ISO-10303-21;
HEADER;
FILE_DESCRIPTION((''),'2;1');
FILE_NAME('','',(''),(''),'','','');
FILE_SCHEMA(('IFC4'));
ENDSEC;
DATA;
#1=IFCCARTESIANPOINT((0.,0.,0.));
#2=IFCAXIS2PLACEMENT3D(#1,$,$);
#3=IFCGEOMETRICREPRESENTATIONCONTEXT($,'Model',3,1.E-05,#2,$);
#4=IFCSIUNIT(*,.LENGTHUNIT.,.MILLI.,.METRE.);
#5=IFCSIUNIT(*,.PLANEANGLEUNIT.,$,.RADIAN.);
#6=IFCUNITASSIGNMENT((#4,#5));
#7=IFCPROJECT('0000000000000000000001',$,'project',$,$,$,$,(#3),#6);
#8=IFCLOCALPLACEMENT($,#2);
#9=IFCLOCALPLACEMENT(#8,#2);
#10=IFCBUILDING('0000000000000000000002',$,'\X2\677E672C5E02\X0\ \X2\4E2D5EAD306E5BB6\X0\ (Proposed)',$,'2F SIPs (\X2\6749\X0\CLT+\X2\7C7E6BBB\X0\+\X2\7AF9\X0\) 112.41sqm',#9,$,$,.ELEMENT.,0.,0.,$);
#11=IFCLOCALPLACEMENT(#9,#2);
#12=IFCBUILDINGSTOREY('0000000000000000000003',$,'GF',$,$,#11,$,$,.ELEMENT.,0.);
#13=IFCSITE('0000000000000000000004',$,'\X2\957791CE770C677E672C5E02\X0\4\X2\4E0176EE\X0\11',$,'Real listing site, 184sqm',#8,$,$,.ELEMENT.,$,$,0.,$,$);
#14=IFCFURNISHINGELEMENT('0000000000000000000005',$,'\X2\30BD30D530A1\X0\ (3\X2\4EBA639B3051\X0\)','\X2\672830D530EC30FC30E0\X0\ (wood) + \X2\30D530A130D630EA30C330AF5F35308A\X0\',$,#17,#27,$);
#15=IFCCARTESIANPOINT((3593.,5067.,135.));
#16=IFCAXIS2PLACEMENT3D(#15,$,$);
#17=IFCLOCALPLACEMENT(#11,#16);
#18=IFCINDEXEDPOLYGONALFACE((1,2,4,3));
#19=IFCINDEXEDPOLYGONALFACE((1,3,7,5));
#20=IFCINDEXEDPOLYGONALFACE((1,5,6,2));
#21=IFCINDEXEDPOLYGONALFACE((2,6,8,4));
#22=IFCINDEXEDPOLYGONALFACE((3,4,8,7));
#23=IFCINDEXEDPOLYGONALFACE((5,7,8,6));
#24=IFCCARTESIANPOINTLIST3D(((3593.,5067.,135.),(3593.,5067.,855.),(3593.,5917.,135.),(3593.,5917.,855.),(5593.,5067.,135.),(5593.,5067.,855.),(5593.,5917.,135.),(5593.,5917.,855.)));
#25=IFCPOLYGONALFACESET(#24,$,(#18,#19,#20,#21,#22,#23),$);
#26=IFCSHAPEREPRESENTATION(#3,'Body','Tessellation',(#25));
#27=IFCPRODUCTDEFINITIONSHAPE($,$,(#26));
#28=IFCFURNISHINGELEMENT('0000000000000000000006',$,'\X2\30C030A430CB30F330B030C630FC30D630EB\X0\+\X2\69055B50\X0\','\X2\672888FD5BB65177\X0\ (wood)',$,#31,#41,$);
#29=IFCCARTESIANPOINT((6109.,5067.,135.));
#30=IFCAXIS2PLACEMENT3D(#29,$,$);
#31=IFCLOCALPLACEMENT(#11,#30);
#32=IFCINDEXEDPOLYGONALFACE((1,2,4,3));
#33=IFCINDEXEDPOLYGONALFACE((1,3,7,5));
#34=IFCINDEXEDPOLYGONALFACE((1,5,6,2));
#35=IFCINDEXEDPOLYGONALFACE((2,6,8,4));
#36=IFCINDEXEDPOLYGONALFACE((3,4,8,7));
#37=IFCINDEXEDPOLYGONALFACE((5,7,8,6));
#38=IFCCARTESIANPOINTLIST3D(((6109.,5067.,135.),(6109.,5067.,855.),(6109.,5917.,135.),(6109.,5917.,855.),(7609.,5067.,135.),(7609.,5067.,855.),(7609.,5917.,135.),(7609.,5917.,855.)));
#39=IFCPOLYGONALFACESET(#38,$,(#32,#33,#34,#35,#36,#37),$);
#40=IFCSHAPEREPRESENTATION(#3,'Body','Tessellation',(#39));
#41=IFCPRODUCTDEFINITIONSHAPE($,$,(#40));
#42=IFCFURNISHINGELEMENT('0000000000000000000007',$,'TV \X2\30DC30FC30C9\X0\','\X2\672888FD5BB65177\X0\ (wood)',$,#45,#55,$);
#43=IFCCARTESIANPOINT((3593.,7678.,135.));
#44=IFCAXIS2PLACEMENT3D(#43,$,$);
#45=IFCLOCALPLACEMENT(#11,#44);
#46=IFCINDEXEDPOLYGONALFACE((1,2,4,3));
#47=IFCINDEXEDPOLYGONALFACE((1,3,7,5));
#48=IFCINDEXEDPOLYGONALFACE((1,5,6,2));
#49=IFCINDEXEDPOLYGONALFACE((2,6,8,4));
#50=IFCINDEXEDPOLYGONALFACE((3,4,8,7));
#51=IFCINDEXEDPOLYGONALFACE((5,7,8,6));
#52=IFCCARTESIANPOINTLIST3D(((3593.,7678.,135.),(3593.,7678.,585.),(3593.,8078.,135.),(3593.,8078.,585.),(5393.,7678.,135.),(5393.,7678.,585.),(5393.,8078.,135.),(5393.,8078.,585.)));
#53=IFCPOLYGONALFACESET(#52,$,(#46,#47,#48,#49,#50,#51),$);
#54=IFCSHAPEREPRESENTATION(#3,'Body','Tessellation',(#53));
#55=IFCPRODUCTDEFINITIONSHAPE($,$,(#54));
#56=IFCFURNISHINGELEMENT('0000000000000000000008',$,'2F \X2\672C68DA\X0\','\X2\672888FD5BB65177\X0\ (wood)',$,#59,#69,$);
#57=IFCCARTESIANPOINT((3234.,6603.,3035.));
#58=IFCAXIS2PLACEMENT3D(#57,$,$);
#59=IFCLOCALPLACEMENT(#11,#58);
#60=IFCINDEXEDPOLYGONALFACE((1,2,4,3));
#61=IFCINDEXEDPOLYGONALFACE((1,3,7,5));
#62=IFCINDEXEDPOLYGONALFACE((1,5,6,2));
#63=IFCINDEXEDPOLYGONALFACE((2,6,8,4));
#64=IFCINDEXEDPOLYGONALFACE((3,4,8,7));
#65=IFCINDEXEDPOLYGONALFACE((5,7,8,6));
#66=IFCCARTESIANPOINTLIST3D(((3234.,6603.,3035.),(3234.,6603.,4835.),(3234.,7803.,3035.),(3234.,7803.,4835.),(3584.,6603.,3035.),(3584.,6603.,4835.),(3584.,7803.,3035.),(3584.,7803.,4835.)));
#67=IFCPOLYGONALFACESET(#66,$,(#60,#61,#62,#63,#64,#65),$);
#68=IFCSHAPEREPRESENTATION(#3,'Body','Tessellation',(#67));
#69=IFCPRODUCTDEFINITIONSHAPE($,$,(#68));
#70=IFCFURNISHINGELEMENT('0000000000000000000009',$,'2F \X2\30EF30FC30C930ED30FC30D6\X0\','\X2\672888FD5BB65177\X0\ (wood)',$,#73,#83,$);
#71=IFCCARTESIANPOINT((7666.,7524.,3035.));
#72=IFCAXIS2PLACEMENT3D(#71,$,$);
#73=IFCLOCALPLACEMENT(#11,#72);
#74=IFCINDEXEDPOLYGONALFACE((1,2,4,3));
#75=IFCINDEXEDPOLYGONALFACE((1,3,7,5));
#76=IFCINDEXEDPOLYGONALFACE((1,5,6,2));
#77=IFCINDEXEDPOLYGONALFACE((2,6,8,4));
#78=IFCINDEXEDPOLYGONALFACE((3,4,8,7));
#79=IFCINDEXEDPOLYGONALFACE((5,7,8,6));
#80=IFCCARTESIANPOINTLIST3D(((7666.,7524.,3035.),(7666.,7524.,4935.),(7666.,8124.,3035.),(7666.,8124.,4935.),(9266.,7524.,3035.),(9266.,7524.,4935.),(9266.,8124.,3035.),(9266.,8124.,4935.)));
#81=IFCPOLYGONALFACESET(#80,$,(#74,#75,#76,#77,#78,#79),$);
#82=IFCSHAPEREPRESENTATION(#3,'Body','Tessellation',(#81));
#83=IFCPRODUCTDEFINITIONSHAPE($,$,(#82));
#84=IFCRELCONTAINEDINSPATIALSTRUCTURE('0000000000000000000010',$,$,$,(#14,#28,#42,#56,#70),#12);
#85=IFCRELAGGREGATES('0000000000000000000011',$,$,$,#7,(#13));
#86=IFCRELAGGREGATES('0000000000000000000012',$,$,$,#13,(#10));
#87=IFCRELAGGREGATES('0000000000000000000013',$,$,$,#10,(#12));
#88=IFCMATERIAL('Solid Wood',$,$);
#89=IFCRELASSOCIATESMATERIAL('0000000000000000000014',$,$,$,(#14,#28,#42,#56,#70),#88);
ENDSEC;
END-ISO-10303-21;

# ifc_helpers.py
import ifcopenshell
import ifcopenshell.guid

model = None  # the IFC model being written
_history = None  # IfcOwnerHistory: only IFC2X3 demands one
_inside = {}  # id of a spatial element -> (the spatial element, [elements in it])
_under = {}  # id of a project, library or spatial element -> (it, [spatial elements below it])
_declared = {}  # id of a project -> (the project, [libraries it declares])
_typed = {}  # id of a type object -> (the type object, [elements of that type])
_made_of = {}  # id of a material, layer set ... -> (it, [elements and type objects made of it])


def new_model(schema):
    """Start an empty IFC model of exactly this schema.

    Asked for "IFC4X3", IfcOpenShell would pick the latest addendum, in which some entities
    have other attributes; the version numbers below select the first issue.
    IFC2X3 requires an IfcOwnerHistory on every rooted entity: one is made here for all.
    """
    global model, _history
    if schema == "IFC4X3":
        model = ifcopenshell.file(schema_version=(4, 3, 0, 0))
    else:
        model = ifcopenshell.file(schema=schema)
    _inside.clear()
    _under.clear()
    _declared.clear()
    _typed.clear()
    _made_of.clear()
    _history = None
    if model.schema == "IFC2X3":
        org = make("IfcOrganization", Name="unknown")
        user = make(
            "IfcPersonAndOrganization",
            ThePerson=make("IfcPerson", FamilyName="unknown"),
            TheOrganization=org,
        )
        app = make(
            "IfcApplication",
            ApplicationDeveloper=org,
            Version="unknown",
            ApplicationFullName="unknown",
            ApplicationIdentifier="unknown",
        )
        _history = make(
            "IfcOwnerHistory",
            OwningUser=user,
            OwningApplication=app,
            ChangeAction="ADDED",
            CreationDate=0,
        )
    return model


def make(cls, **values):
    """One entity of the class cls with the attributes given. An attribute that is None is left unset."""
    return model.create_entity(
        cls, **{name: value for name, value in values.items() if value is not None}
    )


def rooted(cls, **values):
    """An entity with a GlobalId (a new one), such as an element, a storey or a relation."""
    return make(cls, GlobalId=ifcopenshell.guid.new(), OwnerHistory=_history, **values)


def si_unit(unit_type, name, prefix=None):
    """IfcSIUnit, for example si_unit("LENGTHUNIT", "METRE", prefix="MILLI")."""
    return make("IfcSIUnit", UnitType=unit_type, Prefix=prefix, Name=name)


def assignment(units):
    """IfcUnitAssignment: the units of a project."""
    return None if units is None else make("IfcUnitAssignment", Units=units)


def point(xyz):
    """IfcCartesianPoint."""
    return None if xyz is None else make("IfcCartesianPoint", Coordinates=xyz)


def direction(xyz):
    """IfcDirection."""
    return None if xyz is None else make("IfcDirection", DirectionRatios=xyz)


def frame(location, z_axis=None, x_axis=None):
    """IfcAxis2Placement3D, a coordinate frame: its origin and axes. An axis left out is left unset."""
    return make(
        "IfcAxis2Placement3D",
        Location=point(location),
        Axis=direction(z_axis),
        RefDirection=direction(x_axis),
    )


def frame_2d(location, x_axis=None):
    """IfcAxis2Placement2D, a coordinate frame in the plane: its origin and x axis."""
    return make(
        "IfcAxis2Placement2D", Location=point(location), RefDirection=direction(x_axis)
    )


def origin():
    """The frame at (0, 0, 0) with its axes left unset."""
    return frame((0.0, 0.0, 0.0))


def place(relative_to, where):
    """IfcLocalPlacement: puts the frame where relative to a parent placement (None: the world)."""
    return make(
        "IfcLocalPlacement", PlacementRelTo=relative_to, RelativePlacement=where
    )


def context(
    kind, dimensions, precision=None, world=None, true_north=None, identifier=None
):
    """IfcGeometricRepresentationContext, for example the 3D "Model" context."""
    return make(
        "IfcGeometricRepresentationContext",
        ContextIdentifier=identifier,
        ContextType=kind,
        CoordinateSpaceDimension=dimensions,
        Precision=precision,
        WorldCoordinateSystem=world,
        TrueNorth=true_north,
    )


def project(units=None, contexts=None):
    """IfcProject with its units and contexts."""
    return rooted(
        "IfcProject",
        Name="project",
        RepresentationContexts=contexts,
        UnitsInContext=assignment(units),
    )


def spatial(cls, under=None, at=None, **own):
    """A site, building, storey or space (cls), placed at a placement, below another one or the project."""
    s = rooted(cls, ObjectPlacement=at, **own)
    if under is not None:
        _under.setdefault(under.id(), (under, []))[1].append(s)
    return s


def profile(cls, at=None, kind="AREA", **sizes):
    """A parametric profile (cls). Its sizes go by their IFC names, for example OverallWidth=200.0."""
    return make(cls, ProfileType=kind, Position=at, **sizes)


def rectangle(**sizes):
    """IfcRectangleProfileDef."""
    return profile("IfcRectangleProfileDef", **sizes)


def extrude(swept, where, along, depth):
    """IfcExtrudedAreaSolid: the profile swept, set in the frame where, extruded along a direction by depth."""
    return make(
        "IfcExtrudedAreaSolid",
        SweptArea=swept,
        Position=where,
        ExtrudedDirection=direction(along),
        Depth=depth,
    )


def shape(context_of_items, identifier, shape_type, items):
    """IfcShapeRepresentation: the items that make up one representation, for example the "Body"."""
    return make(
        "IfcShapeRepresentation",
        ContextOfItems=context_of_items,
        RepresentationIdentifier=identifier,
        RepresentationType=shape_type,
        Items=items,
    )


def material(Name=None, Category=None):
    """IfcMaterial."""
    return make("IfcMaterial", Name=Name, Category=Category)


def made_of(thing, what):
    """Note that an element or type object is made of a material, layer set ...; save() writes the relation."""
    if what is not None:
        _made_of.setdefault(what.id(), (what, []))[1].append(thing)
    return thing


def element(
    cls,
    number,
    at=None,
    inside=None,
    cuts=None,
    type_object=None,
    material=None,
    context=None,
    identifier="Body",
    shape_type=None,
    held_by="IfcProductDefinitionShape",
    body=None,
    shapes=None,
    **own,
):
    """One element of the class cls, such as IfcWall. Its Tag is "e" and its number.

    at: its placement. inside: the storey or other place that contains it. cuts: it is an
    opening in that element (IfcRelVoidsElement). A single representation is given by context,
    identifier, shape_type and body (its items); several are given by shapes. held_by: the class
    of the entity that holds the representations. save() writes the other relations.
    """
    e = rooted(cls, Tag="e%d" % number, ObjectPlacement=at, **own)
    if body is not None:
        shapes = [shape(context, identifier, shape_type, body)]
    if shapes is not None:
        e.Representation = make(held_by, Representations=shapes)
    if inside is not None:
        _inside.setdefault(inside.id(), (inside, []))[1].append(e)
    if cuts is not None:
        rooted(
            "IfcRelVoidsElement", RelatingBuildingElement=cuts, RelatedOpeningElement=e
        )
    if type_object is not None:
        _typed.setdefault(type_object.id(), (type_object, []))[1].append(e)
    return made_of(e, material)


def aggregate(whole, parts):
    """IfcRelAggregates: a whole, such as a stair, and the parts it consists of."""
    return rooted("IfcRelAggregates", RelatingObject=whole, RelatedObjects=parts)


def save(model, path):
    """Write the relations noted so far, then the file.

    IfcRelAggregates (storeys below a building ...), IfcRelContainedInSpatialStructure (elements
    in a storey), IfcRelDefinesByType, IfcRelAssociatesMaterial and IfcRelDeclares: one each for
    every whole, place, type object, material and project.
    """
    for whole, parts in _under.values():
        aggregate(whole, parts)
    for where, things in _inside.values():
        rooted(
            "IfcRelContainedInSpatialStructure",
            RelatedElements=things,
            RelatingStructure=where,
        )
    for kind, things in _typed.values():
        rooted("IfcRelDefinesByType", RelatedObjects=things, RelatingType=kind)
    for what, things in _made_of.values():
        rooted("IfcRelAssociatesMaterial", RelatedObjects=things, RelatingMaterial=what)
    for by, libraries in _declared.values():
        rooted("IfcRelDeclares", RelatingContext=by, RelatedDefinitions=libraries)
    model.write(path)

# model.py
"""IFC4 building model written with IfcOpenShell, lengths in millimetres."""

from ifc_helpers import new_model, si_unit, frame, frame_2d, origin, place, context, project, spatial, rectangle, extrude, material, element, save


model = new_model("IFC4")

# Units and contexts
model_context = context("Model", 3, precision=1e-05, world=origin())
ifc_project = project(units=[si_unit("LENGTHUNIT", "METRE", prefix="MILLI"), si_unit("PLANEANGLEUNIT", "RADIAN")], contexts=[model_context])

# Site, building, storey
site_placement = place(None, origin())
site = spatial("IfcSite", under=ifc_project, at=site_placement, Name="長野県松本市4丁目11", ObjectType="Real listing site, 184sqm", CompositionType="ELEMENT", RefElevation=0.0)
building_placement = place(site_placement, origin())
building = spatial("IfcBuilding", under=site, at=building_placement, Name="松本市 中庭の家 (Proposed)", ObjectType="2F SIPs (杉CLT+籾殻+竹) 112.41sqm", CompositionType="ELEMENT", ElevationOfRefHeight=0.0, ElevationOfTerrain=0.0)
storey_placement = place(building_placement, origin())
storey = spatial("IfcBuildingStorey", under=building, at=storey_placement, Name="GF", CompositionType="ELEMENT", Elevation=0.0)

# Shared definitions
ifc_material_1 = material(Name="Solid Wood")

# Furnishing elements
furnishing_1_placement = place(storey_placement, frame((3593.0, 5067.0, 135.0)))
element("IfcFurnishingElement", 1, at=furnishing_1_placement, inside=storey, material=ifc_material_1, Name="ソファ (3人掛け)", Description="木フレーム (wood) + ファブリック張り", context=model_context, shape_type="SweptSolid", body=[
    extrude(rectangle(XDim=2000.0, YDim=850.0, at=frame_2d((1000.0, 425.0))), frame((3593.0, 5067.0, 135.0)), (0.0, 0.0, 1.0), 720.0),
])
furnishing_2_placement = place(storey_placement, frame((6109.0, 5067.0, 135.0)))
element("IfcFurnishingElement", 2, at=furnishing_2_placement, inside=storey, material=ifc_material_1, Name="ダイニングテーブル+椅子", Description="木製家具 (wood)", context=model_context, shape_type="SweptSolid", body=[
    extrude(rectangle(XDim=1500.0, YDim=850.0, at=frame_2d((750.0, 425.0))), frame((6109.0, 5067.0, 135.0)), (0.0, 0.0, 1.0), 720.0),
])
furnishing_3_placement = place(storey_placement, frame((3593.0, 7678.0, 135.0)))
element("IfcFurnishingElement", 3, at=furnishing_3_placement, inside=storey, material=ifc_material_1, Name="TV ボード", Description="木製家具 (wood)", context=model_context, shape_type="SweptSolid", body=[
    extrude(rectangle(XDim=1800.0, YDim=400.0, at=frame_2d((900.0, 200.0))), frame((3593.0, 7678.0, 135.0)), (0.0, 0.0, 1.0), 450.0),
])
furnishing_4_placement = place(storey_placement, frame((3234.0, 6603.0, 3035.0)))
element("IfcFurnishingElement", 4, at=furnishing_4_placement, inside=storey, material=ifc_material_1, Name="2F 本棚", Description="木製家具 (wood)", context=model_context, shape_type="SweptSolid", body=[
    extrude(rectangle(XDim=350.0, YDim=1200.0, at=frame_2d((175.0, 600.0))), frame((3234.0, 6603.0, 3035.0)), (0.0, 0.0, 1.0), 1800.0),
])
furnishing_5_placement = place(storey_placement, frame((7666.0, 7524.0, 3035.0)))
element("IfcFurnishingElement", 5, at=furnishing_5_placement, inside=storey, material=ifc_material_1, Name="2F ワードローブ", Description="木製家具 (wood)", context=model_context, shape_type="SweptSolid", body=[
    extrude(rectangle(XDim=1600.0, YDim=600.0, at=frame_2d((800.0, 300.0))), frame((7666.0, 7524.0, 3035.0)), (0.0, 0.0, 1.0), 1900.0),
])

save(model, "model.ifc")
